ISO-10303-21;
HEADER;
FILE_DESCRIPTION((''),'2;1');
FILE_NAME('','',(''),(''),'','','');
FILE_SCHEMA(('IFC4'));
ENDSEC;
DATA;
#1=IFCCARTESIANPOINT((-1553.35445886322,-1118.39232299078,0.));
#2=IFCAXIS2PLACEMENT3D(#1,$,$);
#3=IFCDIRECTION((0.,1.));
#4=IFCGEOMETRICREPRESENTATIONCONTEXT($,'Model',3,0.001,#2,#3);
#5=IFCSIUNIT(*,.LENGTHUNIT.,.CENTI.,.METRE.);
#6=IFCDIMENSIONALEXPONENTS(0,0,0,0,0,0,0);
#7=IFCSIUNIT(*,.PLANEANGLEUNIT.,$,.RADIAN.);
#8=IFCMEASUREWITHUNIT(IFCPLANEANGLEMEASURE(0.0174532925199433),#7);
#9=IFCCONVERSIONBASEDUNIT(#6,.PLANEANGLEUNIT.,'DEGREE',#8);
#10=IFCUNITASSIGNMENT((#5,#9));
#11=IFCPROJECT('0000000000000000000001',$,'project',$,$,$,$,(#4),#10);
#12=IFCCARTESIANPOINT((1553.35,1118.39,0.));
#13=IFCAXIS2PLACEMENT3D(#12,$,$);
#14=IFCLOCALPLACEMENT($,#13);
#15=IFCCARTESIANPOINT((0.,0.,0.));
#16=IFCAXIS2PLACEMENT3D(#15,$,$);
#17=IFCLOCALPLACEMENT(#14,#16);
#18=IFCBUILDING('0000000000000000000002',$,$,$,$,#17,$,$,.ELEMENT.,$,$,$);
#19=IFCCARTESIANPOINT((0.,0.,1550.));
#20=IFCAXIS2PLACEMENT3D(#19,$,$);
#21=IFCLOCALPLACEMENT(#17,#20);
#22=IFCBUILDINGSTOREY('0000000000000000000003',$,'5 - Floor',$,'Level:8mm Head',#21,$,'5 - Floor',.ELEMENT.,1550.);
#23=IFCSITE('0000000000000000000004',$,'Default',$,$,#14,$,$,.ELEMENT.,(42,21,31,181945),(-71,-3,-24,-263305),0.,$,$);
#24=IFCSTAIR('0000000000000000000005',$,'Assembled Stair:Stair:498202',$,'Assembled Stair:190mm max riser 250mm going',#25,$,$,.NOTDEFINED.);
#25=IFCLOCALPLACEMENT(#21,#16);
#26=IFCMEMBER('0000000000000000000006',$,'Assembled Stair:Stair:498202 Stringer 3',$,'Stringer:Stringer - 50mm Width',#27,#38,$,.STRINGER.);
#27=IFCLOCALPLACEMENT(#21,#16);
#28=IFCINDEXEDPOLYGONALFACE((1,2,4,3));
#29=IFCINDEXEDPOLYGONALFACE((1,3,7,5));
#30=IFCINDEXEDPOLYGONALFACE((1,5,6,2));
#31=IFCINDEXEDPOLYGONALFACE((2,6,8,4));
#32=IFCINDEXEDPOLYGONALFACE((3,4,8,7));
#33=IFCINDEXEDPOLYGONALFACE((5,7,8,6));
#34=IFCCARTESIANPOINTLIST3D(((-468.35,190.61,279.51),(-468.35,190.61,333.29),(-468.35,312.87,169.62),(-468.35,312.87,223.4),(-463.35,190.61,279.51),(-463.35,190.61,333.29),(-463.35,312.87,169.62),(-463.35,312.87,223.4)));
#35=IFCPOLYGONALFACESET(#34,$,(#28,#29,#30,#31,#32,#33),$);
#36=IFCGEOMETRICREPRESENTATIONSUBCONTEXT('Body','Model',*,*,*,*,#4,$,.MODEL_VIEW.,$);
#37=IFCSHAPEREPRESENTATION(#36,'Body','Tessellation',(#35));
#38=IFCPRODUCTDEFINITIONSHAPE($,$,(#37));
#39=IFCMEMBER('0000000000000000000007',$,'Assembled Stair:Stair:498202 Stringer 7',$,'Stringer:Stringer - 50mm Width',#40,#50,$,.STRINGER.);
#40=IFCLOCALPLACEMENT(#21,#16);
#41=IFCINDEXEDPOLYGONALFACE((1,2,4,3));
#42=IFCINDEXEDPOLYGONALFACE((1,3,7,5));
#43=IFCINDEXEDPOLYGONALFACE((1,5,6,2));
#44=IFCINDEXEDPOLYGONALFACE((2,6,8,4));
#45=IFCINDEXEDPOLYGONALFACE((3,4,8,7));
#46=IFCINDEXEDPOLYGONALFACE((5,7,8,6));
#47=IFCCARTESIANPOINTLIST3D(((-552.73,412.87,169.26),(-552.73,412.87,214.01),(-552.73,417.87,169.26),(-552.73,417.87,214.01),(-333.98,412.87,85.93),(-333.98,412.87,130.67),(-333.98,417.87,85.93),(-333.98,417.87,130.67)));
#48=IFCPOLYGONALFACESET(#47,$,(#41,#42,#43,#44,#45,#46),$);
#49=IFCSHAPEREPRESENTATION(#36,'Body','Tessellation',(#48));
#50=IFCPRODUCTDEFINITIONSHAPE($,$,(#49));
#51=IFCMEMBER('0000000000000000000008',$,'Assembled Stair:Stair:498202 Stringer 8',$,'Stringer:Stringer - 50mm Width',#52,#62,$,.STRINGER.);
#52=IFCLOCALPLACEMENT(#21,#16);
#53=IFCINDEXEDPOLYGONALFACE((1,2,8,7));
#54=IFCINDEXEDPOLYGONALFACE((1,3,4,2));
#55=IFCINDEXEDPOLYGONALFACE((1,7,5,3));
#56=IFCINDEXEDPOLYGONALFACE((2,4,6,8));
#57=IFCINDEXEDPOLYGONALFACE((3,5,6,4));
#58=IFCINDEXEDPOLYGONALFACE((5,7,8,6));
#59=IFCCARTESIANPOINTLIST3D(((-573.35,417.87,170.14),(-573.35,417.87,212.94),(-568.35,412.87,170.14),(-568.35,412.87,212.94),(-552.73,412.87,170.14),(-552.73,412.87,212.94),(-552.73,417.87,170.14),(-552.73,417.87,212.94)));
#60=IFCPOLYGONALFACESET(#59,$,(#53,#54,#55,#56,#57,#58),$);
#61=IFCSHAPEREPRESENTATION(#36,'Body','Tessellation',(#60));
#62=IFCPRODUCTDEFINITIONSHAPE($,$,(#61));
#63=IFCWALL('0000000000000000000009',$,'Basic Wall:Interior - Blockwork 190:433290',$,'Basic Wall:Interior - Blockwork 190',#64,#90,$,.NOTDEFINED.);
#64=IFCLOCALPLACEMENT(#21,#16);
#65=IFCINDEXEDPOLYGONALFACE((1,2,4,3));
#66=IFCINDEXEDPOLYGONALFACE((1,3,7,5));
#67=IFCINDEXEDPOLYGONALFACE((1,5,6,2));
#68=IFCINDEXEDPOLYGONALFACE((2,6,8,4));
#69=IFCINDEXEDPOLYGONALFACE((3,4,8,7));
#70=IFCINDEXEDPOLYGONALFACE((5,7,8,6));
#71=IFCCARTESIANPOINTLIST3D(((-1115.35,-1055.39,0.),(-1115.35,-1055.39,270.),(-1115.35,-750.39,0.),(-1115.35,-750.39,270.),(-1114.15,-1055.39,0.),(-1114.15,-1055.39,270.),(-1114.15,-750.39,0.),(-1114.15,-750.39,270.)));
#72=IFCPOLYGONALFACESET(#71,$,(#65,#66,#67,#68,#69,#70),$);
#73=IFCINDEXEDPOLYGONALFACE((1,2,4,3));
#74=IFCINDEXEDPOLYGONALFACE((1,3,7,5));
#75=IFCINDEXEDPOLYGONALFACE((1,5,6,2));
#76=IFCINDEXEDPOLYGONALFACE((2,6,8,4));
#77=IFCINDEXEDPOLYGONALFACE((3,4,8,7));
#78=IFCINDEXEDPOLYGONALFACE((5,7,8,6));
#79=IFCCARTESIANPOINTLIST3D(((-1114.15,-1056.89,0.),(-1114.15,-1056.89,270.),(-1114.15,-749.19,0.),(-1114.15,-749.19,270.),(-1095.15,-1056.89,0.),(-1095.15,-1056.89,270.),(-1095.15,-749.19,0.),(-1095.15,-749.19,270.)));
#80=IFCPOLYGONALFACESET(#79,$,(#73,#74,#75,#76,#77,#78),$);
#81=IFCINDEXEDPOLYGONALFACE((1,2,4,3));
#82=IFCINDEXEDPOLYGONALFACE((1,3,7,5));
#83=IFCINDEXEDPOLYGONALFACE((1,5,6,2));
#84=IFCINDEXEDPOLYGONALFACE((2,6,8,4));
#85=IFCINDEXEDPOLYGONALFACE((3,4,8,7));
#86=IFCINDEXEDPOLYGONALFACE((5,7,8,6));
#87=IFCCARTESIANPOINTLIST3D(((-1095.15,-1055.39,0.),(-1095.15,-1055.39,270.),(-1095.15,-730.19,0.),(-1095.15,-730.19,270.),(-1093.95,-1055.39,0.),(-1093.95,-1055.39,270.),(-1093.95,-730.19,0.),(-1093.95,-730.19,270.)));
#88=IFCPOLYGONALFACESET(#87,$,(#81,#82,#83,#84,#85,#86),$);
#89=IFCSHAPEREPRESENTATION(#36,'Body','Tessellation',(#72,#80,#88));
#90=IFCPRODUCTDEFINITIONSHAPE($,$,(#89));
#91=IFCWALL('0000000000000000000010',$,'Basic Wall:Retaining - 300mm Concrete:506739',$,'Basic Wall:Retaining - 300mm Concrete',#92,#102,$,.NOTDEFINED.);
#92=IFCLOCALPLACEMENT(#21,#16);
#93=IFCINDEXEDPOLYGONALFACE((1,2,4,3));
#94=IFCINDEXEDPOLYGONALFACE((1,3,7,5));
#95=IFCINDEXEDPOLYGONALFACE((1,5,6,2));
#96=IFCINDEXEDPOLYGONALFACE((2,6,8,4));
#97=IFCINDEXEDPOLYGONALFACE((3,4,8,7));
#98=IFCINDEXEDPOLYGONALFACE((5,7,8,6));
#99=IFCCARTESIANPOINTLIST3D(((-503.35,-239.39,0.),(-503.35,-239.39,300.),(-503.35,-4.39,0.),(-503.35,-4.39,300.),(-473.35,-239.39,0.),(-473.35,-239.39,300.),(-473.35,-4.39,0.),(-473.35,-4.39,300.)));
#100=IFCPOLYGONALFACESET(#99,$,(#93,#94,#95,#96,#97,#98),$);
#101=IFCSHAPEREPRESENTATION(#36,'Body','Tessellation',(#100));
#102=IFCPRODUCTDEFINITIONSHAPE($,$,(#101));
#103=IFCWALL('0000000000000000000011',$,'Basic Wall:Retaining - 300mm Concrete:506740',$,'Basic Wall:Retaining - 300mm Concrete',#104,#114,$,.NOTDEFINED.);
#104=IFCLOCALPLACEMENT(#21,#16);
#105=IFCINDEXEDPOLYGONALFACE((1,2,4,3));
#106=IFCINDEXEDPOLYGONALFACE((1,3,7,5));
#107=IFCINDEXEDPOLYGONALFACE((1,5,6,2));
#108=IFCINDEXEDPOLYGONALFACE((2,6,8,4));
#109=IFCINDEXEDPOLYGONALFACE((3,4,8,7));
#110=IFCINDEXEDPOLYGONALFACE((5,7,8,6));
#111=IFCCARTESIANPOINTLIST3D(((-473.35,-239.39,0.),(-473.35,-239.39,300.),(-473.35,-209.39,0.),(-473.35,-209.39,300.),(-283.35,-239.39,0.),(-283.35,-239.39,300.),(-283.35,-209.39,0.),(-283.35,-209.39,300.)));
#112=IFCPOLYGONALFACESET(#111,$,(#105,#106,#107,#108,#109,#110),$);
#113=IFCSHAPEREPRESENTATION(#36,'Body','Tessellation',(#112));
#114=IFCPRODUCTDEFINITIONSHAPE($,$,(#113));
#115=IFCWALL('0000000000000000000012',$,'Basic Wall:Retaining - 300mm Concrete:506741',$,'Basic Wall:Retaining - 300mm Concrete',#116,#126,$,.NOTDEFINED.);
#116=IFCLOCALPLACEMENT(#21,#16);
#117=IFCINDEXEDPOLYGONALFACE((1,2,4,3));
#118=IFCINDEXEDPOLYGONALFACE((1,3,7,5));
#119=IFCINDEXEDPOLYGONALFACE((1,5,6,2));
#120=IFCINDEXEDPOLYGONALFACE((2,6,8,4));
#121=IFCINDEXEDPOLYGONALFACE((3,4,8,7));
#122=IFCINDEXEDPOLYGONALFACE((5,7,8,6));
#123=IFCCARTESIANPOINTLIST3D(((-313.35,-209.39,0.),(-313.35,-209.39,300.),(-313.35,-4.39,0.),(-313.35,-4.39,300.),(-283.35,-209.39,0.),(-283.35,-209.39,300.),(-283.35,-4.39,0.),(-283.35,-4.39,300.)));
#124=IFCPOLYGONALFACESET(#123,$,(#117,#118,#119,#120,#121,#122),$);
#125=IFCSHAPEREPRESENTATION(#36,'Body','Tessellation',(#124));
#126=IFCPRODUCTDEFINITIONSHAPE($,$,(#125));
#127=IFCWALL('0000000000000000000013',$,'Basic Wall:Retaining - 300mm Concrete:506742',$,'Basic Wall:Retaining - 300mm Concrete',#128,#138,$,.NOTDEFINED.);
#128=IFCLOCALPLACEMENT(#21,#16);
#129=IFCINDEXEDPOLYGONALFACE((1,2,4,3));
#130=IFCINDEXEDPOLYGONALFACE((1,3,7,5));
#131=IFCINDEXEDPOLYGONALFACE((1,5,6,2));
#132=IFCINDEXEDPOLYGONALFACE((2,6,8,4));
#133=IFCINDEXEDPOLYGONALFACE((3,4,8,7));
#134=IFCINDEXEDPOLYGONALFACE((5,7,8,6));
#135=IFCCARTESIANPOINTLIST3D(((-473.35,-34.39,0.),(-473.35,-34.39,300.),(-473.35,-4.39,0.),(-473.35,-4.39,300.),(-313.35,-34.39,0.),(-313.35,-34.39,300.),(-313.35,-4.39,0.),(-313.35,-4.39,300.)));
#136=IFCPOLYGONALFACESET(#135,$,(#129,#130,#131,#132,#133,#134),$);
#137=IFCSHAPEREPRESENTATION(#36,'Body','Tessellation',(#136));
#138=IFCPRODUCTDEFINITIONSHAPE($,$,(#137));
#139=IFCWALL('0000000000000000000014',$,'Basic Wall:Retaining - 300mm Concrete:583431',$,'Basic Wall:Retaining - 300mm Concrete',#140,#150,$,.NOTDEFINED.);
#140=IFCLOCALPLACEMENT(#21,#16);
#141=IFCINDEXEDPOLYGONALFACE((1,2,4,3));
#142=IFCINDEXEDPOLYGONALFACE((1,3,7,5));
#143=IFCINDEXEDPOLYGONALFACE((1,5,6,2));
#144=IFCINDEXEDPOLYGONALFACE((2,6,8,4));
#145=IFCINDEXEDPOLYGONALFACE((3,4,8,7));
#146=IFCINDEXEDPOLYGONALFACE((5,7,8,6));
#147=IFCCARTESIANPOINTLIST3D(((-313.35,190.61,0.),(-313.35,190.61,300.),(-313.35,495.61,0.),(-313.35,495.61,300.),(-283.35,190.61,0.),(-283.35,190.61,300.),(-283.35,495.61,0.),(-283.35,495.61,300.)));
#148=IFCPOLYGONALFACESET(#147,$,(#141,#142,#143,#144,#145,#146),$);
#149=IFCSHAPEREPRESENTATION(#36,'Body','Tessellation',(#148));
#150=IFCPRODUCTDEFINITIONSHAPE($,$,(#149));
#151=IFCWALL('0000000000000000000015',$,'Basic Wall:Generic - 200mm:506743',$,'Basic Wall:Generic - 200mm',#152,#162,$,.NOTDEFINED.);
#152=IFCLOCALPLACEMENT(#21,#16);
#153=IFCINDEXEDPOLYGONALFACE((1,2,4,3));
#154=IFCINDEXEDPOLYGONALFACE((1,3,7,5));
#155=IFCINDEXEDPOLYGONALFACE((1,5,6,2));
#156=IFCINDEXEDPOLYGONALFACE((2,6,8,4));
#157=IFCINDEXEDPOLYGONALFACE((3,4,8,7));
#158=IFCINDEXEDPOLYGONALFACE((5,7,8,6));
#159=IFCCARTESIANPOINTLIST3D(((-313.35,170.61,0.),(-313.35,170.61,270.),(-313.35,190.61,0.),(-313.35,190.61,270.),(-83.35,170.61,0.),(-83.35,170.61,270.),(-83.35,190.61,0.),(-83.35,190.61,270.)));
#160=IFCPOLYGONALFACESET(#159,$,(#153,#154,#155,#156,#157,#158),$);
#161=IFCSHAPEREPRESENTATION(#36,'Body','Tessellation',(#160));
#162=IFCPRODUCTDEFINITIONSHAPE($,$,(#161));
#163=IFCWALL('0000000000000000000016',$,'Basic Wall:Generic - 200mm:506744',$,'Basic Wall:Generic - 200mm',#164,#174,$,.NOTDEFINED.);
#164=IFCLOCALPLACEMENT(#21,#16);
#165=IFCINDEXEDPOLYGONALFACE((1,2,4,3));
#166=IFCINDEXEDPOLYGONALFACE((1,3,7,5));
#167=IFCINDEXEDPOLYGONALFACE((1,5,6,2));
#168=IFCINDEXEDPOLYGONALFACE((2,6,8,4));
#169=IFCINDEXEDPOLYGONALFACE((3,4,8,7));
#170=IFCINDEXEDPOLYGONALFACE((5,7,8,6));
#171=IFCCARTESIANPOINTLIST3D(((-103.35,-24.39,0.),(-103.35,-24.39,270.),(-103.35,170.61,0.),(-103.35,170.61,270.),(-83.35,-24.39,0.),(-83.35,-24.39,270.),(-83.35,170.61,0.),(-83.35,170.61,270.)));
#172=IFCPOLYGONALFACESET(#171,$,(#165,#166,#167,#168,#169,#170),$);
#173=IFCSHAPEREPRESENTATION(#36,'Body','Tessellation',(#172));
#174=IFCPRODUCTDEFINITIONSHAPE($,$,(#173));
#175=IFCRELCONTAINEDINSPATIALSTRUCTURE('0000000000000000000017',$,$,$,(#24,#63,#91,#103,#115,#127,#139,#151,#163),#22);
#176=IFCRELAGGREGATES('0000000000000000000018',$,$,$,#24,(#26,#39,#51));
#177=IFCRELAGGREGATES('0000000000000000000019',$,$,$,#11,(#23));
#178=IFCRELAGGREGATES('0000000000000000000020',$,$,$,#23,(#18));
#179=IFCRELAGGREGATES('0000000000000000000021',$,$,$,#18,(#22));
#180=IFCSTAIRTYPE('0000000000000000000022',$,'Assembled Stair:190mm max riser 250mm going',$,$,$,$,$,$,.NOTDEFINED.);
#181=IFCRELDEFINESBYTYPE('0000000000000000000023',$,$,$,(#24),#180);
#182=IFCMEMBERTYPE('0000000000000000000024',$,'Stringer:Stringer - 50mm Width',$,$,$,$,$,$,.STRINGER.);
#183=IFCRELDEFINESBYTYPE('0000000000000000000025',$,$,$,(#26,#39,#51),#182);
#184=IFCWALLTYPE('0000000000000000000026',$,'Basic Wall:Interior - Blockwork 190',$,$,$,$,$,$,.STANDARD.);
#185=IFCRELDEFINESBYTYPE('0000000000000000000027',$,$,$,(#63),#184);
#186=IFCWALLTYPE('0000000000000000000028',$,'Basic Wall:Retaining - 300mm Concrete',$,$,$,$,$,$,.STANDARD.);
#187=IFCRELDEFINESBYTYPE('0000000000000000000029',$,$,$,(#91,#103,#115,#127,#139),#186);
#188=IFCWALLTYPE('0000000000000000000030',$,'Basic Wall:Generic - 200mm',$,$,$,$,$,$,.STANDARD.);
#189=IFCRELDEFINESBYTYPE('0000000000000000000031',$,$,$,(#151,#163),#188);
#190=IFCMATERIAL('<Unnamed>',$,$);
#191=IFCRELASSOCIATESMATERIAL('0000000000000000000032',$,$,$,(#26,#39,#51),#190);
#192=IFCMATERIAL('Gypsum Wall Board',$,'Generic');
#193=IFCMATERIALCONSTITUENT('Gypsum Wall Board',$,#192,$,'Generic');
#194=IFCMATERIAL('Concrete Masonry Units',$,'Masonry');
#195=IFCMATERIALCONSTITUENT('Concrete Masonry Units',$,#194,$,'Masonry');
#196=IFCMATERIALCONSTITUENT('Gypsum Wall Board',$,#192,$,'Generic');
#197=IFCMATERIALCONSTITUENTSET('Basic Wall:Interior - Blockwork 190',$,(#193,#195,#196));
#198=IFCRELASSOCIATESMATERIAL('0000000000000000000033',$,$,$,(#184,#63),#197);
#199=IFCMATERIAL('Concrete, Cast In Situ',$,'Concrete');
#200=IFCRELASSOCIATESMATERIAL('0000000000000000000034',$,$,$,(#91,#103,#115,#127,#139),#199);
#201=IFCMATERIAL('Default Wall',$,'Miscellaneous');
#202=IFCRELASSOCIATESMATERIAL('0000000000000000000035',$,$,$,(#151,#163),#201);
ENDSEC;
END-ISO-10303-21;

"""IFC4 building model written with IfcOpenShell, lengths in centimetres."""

from ifc_helpers import new_model, entity, si_unit, converted_unit, direction, frame, origin, place, context, subcontext, project, spatial, indexed_curve, outline, extrude, material, constituent, constituent_set, type_object, element, aggregate, save


model = new_model("IFC4")

# Units and contexts
model_context = context("Model", 3, precision=0.001, world=frame((-1553.35445886322, -1118.39232299078, 0.0)), true_north=direction((0.0, 1.0)))
body_context = subcontext(model_context, "Body", "Model", "MODEL_VIEW")
ifc_project = project(units=[si_unit("LENGTHUNIT", "METRE", prefix="CENTI"), converted_unit("PLANEANGLEUNIT", "DEGREE", entity("IfcPlaneAngleMeasure", 0.0174532925199433), si_unit("PLANEANGLEUNIT", "RADIAN"), dimensions=[0, 0, 0, 0, 0, 0, 0])], contexts=[model_context])

# Site, building, storey
site_placement = place(None, frame((1553.35, 1118.39, 0.0)))
site = spatial("IfcSite", under=ifc_project, at=site_placement, Name="Default", CompositionType="ELEMENT", RefLatitude=(42, 21, 31, 181945), RefLongitude=(-71, -3, -24, -263305), RefElevation=0.0)
building_placement = place(site_placement, origin())
building = spatial("IfcBuilding", under=site, at=building_placement, CompositionType="ELEMENT")
storey_placement = place(building_placement, frame((0.0, 0.0, 1550.0)))
storey = spatial("IfcBuildingStorey", under=building, at=storey_placement, Name="5 - Floor", ObjectType="Level:8mm Head", LongName="5 - Floor", CompositionType="ELEMENT", Elevation=1550.0)

# Stair, members
stair_type = type_object("IfcStairType", Name="Assembled Stair:190mm max riser 250mm going", PredefinedType="NOTDEFINED")
stair_placement = place(storey_placement, origin())
stair = element("IfcStair", 1, at=stair_placement, inside=storey, type_object=stair_type, Name="Assembled Stair:Stair:498202", ObjectType="Assembled Stair:190mm max riser 250mm going", PredefinedType="NOTDEFINED")
ifc_material_1 = material(Name="<Unnamed>")
member_type = type_object("IfcMemberType", Name="Stringer:Stringer - 50mm Width", PredefinedType="STRINGER")
member_1_placement = place(stair_placement, origin())
member_1 = element("IfcMember", 2, at=member_1_placement, type_object=member_type, material=ifc_material_1, Name="Assembled Stair:Stair:498202 Stringer 3", ObjectType="Stringer:Stringer - 50mm Width", PredefinedType="STRINGER", context=body_context, shape_type="SweptSolid", body=[
    extrude(outline(indexed_curve([(-64.22, -20.0), (100.17, -20.0), (64.22, 20.0), (-100.17, 20.0), (-64.22, -20.0)], self_intersect=False)), frame((-468.35, 251.74, 251.46), z_axis=(1.0, 0.0, 0.0), x_axis=(0.0, -0.74373, 0.668481)), (0.0, 0.0, 1.0), 5.0),
])
member_2_placement = place(stair_placement, origin())
member_2 = element("IfcMember", 3, at=member_2_placement, type_object=member_type, material=ifc_material_1, Name="Assembled Stair:Stair:498202 Stringer 7", ObjectType="Stringer:Stringer - 50mm Width", PredefinedType="STRINGER", context=body_context, shape_type="SweptSolid", body=[
    extrude(outline(indexed_curve([(-125.01, -20.91), (109.08, -20.91), (125.01, 20.91), (-109.08, 20.91), (-125.01, -20.91)], self_intersect=False)), frame((-443.35, 412.87, 149.97), z_axis=(0.0, 1.0, 0.0), x_axis=(-0.934489, 0.0, 0.355992)), (0.0, 0.0, 1.0), 5.0),
])
member_3_placement = place(stair_placement, origin())
member_3 = element("IfcMember", 4, at=member_3_placement, type_object=member_type, material=ifc_material_1, Name="Assembled Stair:Stair:498202 Stringer 8", ObjectType="Stringer:Stringer - 50mm Width", PredefinedType="STRINGER", context=body_context, shape_type="SweptSolid", body=[
    extrude(outline(indexed_curve([(-9.06, -2.5), (11.56, -2.5), (6.56, 2.5), (-9.06, 2.5), (-9.06, -2.5)], self_intersect=False)), frame((-561.79, 415.37, 170.14), z_axis=(0.0, 0.0, 1.0), x_axis=(-1.0, 0.0, 0.0)), (0.0, 0.0, 1.0), 42.8),
])

# Shared definitions
ifc_material_2 = material(Name="Gypsum Wall Board", Category="Generic")
ifc_constituent_1 = constituent(ifc_material_2, Name="Gypsum Wall Board", Category="Generic")
ifc_material_3 = material(Name="Concrete Masonry Units", Category="Masonry")
ifc_constituent_2 = constituent(ifc_material_3, Name="Concrete Masonry Units", Category="Masonry")
ifc_constituent_3 = constituent(ifc_material_2, Name="Gypsum Wall Board", Category="Generic")
ifc_constituent_set_1 = constituent_set(constituents=[ifc_constituent_1, ifc_constituent_2, ifc_constituent_3], Name="Basic Wall:Interior - Blockwork 190")
wall_type_1 = type_object("IfcWallType", Name="Basic Wall:Interior - Blockwork 190", PredefinedType="STANDARD", material=ifc_constituent_set_1)

# Walls
wall_1_placement = place(storey_placement, frame((-1104.65, -750.39, 0.0), z_axis=(0.0, 0.0, 1.0), x_axis=(0.0, -1.0, 0.0)))
element("IfcWall", 5, at=wall_1_placement, inside=storey, type_object=wall_type_1, material=ifc_constituent_set_1, Name="Basic Wall:Interior - Blockwork 190:433290", ObjectType="Basic Wall:Interior - Blockwork 190", PredefinedType="NOTDEFINED", context=body_context, shape_type="SweptSolid", body=[
    extrude(outline(indexed_curve([(-0.6, -152.5), (0.6, -152.5), (0.6, 152.5), (-0.6, 152.5), (-0.6, -152.5)], self_intersect=False)), frame((152.5, -10.1, 0.0), z_axis=(0.0, 0.0, 1.0), x_axis=(0.0, 1.0, 0.0)), (0.0, 0.0, 1.0), 270.0),
    extrude(outline(indexed_curve([(-153.85, -9.5), (153.85, -9.5), (153.85, 9.5), (-153.85, 9.5), (-153.85, -9.5)], self_intersect=False)), frame((152.65, 0.0, 0.0)), (0.0, 0.0, 1.0), 270.0),
    extrude(outline(indexed_curve([(-0.6, -162.6), (0.6, -162.6), (0.6, 162.6), (-0.6, 162.6), (-0.6, -162.6)], self_intersect=False)), frame((142.4, 10.1, 0.0), z_axis=(0.0, 0.0, 1.0), x_axis=(0.0, -1.0, 0.0)), (0.0, 0.0, 1.0), 270.0),
])
ifc_material_4 = material(Name="Concrete, Cast In Situ", Category="Concrete")
wall_type_2 = type_object("IfcWallType", Name="Basic Wall:Retaining - 300mm Concrete", PredefinedType="STANDARD")
wall_2_placement = place(storey_placement, frame((-488.35, -4.39, 0.0), z_axis=(0.0, 0.0, 1.0), x_axis=(0.0, -1.0, 0.0)))
element("IfcWall", 6, at=wall_2_placement, inside=storey, type_object=wall_type_2, material=ifc_material_4, Name="Basic Wall:Retaining - 300mm Concrete:506739", ObjectType="Basic Wall:Retaining - 300mm Concrete", PredefinedType="NOTDEFINED", context=body_context, shape_type="SweptSolid", body=[
    extrude(outline(indexed_curve([(235.0, 15.0), (0.0, 15.0), (0.0, -15.0), (235.0, -15.0), (235.0, 15.0)], self_intersect=False)), origin(), (0.0, 0.0, 1.0), 300.0),
])
wall_3_placement = place(storey_placement, frame((-473.35, -224.39, 0.0)))
element("IfcWall", 7, at=wall_3_placement, inside=storey, type_object=wall_type_2, material=ifc_material_4, Name="Basic Wall:Retaining - 300mm Concrete:506740", ObjectType="Basic Wall:Retaining - 300mm Concrete", PredefinedType="NOTDEFINED", context=body_context, shape_type="SweptSolid", body=[
    extrude(outline(indexed_curve([(190.0, 15.0), (0.0, 15.0), (0.0, -15.0), (190.0, -15.0), (190.0, 15.0)], self_intersect=False)), origin(), (0.0, 0.0, 1.0), 300.0),
])
wall_4_placement = place(storey_placement, frame((-298.35, -209.39, 0.0), z_axis=(0.0, 0.0, 1.0), x_axis=(0.0, 1.0, 0.0)))
element("IfcWall", 8, at=wall_4_placement, inside=storey, type_object=wall_type_2, material=ifc_material_4, Name="Basic Wall:Retaining - 300mm Concrete:506741", ObjectType="Basic Wall:Retaining - 300mm Concrete", PredefinedType="NOTDEFINED", context=body_context, shape_type="SweptSolid", body=[
    extrude(outline(indexed_curve([(205.0, 15.0), (0.0, 15.0), (0.0, -15.0), (205.0, -15.0), (205.0, 15.0)], self_intersect=False)), origin(), (0.0, 0.0, 1.0), 300.0),
])
wall_5_placement = place(storey_placement, frame((-313.35, -19.39, 0.0), z_axis=(0.0, 0.0, 1.0), x_axis=(-1.0, 0.0, 0.0)))
element("IfcWall", 9, at=wall_5_placement, inside=storey, type_object=wall_type_2, material=ifc_material_4, Name="Basic Wall:Retaining - 300mm Concrete:506742", ObjectType="Basic Wall:Retaining - 300mm Concrete", PredefinedType="NOTDEFINED", context=body_context, shape_type="SweptSolid", body=[
    extrude(outline(indexed_curve([(160.0, 15.0), (0.0, 15.0), (0.0, -15.0), (160.0, -15.0), (160.0, 15.0)], self_intersect=False)), origin(), (0.0, 0.0, 1.0), 300.0),
])
wall_6_placement = place(storey_placement, frame((-298.35, 495.61, 0.0), z_axis=(0.0, 0.0, 1.0), x_axis=(0.0, -1.0, 0.0)))
element("IfcWall", 10, at=wall_6_placement, inside=storey, type_object=wall_type_2, material=ifc_material_4, Name="Basic Wall:Retaining - 300mm Concrete:583431", ObjectType="Basic Wall:Retaining - 300mm Concrete", PredefinedType="NOTDEFINED", context=body_context, shape_type="SweptSolid", body=[
    extrude(outline(indexed_curve([(305.0, 15.0), (0.0, 15.0), (0.0, -15.0), (305.0, -15.0), (305.0, 15.0)], self_intersect=False)), origin(), (0.0, 0.0, 1.0), 300.0),
])
ifc_material_5 = material(Name="Default Wall", Category="Miscellaneous")
wall_type_3 = type_object("IfcWallType", Name="Basic Wall:Generic - 200mm", PredefinedType="STANDARD")
wall_7_placement = place(storey_placement, frame((-313.35, 180.61, 0.0)))
element("IfcWall", 11, at=wall_7_placement, inside=storey, type_object=wall_type_3, material=ifc_material_5, Name="Basic Wall:Generic - 200mm:506743", ObjectType="Basic Wall:Generic - 200mm", PredefinedType="NOTDEFINED", context=body_context, shape_type="SweptSolid", body=[
    extrude(outline(indexed_curve([(230.0, 10.0), (0.0, 10.0), (0.0, -10.0), (230.0, -10.0), (230.0, 10.0)], self_intersect=False)), origin(), (0.0, 0.0, 1.0), 270.0),
])
wall_8_placement = place(storey_placement, frame((-93.35, 170.61, 0.0), z_axis=(0.0, 0.0, 1.0), x_axis=(0.0, -1.0, 0.0)))
element("IfcWall", 12, at=wall_8_placement, inside=storey, type_object=wall_type_3, material=ifc_material_5, Name="Basic Wall:Generic - 200mm:506744", ObjectType="Basic Wall:Generic - 200mm", PredefinedType="NOTDEFINED", context=body_context, shape_type="SweptSolid", body=[
    extrude(outline(indexed_curve([(195.0, 10.0), (0.0, 10.0), (0.0, -10.0), (195.0, -10.0), (195.0, 10.0)], self_intersect=False)), origin(), (0.0, 0.0, 1.0), 270.0),
])

aggregate(stair, [member_1, member_2, member_3])

save(model, "model.ifc")
